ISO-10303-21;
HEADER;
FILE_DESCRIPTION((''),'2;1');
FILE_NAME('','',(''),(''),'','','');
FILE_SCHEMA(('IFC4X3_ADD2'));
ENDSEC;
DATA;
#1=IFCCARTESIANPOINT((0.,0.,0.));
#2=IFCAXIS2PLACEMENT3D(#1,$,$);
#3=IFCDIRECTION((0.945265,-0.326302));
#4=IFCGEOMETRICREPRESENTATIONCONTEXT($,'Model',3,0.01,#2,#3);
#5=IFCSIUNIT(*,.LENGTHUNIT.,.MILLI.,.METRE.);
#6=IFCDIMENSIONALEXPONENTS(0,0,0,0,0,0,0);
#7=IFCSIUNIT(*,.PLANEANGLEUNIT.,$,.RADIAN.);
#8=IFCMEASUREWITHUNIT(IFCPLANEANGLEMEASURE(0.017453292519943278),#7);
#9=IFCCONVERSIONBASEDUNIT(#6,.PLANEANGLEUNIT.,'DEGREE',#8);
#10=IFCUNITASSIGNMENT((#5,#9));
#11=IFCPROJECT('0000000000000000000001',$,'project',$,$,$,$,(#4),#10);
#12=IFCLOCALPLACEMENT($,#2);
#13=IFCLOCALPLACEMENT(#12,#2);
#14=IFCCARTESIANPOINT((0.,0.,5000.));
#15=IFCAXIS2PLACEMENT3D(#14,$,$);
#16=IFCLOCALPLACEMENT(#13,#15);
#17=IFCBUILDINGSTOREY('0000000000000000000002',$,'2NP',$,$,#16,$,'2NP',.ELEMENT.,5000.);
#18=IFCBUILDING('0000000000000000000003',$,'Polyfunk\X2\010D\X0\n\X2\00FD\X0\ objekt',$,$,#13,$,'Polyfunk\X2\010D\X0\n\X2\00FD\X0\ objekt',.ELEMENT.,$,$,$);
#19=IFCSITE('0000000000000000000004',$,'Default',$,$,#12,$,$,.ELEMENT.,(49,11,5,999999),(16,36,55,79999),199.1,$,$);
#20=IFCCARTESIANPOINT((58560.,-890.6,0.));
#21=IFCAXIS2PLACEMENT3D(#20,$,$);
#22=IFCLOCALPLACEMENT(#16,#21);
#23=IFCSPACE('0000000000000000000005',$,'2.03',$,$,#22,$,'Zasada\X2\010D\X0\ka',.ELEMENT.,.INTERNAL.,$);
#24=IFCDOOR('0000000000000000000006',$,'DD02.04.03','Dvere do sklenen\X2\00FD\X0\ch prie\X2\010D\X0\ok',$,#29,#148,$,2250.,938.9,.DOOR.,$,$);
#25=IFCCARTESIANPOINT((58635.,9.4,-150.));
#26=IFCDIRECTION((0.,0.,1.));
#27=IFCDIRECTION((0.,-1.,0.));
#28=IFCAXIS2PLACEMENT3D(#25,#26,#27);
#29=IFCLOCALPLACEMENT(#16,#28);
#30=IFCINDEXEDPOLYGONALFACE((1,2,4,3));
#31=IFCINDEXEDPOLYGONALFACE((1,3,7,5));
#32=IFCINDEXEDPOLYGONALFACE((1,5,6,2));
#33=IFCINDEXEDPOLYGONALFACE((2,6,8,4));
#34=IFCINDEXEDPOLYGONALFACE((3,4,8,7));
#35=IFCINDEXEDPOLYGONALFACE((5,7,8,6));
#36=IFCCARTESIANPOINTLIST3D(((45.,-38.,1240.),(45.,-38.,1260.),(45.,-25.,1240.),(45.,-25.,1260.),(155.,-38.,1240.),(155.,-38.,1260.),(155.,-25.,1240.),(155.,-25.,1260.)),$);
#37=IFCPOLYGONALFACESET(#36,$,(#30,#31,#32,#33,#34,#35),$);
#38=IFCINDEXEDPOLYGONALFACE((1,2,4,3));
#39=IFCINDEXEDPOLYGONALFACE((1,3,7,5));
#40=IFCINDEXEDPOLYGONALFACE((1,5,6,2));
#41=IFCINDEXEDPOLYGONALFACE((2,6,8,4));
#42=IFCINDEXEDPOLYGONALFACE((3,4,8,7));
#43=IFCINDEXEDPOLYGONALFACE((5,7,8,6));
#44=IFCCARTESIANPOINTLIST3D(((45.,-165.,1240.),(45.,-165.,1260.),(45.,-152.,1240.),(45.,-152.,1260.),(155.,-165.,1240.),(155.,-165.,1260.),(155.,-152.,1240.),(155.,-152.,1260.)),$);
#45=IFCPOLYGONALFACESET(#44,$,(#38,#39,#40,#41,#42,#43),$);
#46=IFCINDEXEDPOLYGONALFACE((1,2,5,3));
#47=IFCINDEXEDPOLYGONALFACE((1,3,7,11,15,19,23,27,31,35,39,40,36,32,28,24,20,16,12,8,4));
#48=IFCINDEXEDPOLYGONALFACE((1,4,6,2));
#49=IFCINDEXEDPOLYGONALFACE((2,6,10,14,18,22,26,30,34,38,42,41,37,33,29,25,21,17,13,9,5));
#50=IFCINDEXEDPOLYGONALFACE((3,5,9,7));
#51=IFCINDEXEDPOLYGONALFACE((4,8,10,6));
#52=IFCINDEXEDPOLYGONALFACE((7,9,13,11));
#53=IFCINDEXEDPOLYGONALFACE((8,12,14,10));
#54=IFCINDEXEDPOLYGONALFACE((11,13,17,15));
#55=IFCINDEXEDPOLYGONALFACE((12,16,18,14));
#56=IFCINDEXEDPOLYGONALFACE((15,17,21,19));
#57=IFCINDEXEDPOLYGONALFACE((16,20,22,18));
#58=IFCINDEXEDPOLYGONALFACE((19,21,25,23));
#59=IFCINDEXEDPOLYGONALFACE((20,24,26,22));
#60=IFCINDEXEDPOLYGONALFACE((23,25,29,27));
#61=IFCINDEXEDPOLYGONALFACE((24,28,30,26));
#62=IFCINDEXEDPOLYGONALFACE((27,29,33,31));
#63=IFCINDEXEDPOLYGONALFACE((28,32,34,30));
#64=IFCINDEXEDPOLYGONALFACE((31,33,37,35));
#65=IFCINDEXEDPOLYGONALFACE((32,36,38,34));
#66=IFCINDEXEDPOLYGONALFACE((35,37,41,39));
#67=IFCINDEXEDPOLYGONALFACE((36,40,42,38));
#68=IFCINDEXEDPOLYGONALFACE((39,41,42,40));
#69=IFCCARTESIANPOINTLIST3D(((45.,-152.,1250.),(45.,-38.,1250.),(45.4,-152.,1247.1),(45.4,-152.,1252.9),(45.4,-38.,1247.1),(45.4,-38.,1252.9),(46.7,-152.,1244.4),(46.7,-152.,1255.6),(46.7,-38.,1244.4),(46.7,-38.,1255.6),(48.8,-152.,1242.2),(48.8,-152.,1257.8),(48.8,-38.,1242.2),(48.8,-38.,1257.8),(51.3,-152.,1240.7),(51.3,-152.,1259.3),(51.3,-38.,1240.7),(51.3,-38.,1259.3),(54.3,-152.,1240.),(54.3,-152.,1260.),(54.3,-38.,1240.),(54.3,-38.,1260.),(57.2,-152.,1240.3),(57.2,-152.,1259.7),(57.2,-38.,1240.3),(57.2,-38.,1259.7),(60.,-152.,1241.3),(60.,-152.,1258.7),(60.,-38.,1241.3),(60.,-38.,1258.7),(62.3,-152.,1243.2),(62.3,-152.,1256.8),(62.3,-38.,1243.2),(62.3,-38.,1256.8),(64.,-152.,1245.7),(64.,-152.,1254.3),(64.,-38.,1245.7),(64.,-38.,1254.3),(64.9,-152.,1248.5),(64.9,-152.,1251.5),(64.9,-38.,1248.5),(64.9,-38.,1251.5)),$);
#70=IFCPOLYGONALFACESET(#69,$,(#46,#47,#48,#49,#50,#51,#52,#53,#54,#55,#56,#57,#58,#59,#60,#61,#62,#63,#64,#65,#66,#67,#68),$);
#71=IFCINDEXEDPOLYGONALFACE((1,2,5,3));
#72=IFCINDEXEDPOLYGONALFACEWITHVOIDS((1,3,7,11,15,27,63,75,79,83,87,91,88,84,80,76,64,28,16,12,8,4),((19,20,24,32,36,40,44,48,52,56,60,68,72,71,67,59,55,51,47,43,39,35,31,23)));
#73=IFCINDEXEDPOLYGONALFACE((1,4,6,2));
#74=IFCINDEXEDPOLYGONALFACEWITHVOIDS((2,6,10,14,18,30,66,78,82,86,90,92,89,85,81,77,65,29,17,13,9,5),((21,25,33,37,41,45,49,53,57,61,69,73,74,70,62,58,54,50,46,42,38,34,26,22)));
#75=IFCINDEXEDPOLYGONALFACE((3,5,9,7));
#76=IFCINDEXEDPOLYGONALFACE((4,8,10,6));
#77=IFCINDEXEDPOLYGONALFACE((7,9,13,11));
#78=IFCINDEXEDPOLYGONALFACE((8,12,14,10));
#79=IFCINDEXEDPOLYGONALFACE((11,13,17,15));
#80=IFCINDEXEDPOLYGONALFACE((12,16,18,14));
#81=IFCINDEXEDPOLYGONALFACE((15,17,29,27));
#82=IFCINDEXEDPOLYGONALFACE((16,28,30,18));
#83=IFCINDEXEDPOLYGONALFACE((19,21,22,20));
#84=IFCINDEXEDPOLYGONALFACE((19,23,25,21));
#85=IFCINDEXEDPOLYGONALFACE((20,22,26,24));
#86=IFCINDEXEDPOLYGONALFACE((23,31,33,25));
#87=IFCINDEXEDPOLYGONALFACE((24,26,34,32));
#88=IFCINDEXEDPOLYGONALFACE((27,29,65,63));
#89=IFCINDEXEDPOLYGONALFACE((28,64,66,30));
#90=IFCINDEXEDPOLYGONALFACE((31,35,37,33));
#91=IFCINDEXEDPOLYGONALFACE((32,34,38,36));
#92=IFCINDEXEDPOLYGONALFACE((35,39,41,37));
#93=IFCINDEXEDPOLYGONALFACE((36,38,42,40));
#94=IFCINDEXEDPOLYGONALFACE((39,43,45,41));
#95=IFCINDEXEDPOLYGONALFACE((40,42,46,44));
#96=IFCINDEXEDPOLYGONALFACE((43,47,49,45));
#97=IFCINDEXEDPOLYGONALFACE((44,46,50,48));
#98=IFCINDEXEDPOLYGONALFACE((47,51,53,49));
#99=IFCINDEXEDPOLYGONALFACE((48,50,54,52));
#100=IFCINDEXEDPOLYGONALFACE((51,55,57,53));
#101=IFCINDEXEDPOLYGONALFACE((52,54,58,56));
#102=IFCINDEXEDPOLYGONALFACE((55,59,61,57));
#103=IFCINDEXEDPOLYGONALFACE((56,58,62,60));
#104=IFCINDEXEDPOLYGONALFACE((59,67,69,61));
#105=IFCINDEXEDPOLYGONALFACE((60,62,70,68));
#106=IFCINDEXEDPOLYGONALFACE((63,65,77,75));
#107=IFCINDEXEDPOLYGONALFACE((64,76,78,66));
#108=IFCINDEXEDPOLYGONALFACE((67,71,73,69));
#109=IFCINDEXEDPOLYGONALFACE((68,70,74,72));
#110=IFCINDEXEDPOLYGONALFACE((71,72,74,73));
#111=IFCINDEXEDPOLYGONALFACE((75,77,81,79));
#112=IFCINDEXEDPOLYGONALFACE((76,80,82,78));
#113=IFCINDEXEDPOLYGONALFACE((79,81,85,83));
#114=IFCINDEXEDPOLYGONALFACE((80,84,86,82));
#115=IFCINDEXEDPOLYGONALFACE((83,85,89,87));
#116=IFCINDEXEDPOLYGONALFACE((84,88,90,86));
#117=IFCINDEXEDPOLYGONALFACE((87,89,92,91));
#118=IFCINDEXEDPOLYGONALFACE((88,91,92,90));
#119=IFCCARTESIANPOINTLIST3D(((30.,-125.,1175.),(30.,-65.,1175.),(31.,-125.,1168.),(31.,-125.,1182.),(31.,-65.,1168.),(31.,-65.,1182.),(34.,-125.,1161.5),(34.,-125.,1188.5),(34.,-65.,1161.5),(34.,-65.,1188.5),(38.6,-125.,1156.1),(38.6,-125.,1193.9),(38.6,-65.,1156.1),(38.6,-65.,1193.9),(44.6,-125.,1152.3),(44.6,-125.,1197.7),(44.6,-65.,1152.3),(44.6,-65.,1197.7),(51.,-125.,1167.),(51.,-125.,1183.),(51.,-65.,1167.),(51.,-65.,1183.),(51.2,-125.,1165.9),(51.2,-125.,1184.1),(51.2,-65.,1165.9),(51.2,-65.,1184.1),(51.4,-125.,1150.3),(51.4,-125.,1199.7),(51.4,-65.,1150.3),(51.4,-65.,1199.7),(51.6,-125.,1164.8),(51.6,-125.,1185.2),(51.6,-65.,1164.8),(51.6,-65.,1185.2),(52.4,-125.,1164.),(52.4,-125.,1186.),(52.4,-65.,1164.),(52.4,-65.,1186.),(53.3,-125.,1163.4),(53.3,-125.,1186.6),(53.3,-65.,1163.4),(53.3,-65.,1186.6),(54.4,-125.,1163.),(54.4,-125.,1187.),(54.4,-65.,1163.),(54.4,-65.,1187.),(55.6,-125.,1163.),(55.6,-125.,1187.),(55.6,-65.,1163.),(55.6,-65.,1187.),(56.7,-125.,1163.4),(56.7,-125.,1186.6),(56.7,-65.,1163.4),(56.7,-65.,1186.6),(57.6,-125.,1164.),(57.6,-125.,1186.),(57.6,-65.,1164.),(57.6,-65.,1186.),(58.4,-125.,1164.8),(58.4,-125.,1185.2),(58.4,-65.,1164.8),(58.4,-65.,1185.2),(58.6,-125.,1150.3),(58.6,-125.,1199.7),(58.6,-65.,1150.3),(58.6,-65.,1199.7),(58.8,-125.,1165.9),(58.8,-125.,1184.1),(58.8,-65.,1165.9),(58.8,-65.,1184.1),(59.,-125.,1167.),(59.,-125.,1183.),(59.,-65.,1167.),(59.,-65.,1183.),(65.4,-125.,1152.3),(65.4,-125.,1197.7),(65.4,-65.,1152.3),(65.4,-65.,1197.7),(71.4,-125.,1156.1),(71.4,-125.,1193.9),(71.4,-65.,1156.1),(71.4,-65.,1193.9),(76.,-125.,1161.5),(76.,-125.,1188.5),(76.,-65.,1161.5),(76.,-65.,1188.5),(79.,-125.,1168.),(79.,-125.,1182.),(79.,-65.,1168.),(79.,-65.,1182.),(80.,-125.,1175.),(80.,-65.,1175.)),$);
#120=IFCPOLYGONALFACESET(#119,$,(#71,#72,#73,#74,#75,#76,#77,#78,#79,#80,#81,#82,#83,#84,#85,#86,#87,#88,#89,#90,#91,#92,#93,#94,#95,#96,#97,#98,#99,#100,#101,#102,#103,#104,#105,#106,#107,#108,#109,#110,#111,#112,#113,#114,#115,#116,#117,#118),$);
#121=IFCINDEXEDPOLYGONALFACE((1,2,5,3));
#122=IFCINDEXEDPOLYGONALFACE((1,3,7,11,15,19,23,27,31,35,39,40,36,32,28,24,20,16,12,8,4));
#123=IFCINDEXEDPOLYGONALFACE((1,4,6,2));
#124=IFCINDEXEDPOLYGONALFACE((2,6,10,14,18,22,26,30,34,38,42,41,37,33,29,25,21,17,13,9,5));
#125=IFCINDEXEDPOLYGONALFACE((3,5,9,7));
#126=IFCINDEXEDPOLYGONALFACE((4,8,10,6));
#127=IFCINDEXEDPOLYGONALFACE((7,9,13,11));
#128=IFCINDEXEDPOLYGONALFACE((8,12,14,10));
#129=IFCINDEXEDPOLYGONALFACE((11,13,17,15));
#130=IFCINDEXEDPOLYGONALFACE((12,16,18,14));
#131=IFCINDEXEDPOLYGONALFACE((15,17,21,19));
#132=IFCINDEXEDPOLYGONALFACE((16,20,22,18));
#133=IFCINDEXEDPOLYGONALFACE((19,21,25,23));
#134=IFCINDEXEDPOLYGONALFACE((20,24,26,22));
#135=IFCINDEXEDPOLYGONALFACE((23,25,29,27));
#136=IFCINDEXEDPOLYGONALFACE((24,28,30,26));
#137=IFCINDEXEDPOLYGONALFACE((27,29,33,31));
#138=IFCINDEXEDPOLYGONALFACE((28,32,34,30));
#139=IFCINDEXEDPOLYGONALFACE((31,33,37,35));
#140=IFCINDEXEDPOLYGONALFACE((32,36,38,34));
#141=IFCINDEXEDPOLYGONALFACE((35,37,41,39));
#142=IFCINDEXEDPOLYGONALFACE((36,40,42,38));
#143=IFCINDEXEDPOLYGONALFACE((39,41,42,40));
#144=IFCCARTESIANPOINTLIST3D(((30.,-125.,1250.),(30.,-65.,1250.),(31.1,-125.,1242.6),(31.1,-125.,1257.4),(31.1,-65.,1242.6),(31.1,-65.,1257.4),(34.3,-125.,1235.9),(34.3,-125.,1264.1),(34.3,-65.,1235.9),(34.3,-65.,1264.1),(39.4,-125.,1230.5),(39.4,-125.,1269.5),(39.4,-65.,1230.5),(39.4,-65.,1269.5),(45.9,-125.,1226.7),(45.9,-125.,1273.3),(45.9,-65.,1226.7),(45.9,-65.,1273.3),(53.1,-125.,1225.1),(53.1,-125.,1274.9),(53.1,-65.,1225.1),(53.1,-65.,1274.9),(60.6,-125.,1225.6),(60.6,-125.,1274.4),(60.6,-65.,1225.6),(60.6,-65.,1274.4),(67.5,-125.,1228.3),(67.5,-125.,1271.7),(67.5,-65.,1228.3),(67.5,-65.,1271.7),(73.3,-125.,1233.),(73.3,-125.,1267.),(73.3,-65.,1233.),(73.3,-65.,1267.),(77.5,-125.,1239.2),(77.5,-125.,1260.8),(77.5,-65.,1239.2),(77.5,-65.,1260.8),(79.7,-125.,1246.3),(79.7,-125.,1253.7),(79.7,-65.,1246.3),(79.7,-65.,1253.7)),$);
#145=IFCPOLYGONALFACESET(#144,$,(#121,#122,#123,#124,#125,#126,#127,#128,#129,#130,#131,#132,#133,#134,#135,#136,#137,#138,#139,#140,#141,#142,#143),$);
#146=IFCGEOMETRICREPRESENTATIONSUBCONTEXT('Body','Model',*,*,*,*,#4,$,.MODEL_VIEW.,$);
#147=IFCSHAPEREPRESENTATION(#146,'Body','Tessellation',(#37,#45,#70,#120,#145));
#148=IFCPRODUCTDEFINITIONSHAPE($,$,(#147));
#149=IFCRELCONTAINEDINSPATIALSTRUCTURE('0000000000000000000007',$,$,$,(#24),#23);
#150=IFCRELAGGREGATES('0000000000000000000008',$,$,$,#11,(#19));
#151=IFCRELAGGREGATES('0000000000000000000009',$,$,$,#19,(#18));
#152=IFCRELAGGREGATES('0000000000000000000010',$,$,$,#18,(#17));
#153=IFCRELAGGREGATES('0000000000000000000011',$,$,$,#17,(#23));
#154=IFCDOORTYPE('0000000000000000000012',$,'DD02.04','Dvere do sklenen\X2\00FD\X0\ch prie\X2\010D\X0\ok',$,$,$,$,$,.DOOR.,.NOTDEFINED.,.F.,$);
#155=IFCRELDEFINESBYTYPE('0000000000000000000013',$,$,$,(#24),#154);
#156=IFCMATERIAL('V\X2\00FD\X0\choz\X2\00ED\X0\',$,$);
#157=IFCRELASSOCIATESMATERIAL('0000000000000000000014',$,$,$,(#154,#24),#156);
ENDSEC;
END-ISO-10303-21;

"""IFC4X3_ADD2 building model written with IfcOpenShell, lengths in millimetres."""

from ifc_helpers import new_model, entity, si_unit, converted_unit, direction, frame, frame_2d, origin, origin_2d_with_axis, place, context, subcontext, project, spatial, polyline, circle_curve, parameter, trimmed, segment, composite_curve, rectangle, circle, outline, extrude, source, transform, mapped, material, type_object, type_shapes, element, save


model = new_model("IFC4X3_ADD2")

# Units and contexts
model_context = context("Model", 3, precision=0.01, world=origin(), true_north=direction((0.945265, -0.326302)))
body_context = subcontext(model_context, "Body", "Model", "MODEL_VIEW")
ifc_project = project(units=[si_unit("LENGTHUNIT", "METRE", prefix="MILLI"), converted_unit("PLANEANGLEUNIT", "DEGREE", entity("IfcPlaneAngleMeasure", 0.017453292519943278), si_unit("PLANEANGLEUNIT", "RADIAN"), dimensions=[0, 0, 0, 0, 0, 0, 0])], contexts=[model_context])

# Site, building, storey
site_placement = place(None, origin())
site = spatial("IfcSite", under=ifc_project, at=site_placement, Name="Default", CompositionType="ELEMENT", RefLatitude=(49, 11, 5, 999999), RefLongitude=(16, 36, 55, 79999), RefElevation=199.1)
building_placement = place(site_placement, origin())
building = spatial("IfcBuilding", under=site, at=building_placement, Name="Polyfunkčný objekt", LongName="Polyfunkčný objekt", CompositionType="ELEMENT")
storey_placement = place(building_placement, frame((0.0, 0.0, 5000.0)))
storey = spatial("IfcBuildingStorey", under=building, at=storey_placement, Name="2NP", LongName="2NP", CompositionType="ELEMENT", Elevation=5000.0)

# Shared definitions
space_placement = place(storey_placement, frame((58560.0, -890.6, 0.0)))
space = spatial("IfcSpace", under=storey, at=space_placement, Name="2.03", LongName="Zasadačka", CompositionType="ELEMENT", PredefinedType="INTERNAL")

# Door
ifc_material_1 = material(Name="Výchozí")
door_type = type_object("IfcDoorType", Name="DD02.04", Description="Dvere do sklenených priečok", OperationType="NOTDEFINED", ParameterTakesPrecedence=False, PredefinedType="DOOR", material=ifc_material_1)
shared_shape_1 = source(origin(), body_context, "Body", "SweptSolid", [
    extrude(rectangle(XDim=110.0, YDim=13.0, at=frame_2d((0.0, 0.0), x_axis=(1.0, 0.0))), frame((100.0, -31.5, 1240.0)), (0.0, 0.0, 1.0), 20.0),
    extrude(rectangle(XDim=110.0, YDim=13.0, at=origin_2d_with_axis()), frame((100.0, -158.5, 1240.0), z_axis=(0.0, 0.0, 1.0), x_axis=(-1.0, 0.0, 0.0)), (0.0, 0.0, 1.0), 20.0),
    extrude(circle(Radius=10.0, at=origin_2d_with_axis()), frame((55.0, -152.0, 1250.0), z_axis=(0.0, 1.0, 0.0), x_axis=(-1.0, 0.0, 0.0)), (0.0, 0.0, 1.0), 114.0),
    extrude(outline(composite_curve([segment(trimmed(circle_curve(origin_2d_with_axis(), 25.0), [parameter(180.0)], [parameter(360.0)], True, "PARAMETER"), True, "CONTINUOUS"), segment(trimmed(circle_curve(origin_2d_with_axis(), 25.0), [parameter(0.0)], [parameter(180.0)], True, "PARAMETER"), True, "CONTINUOUS")], self_intersect=False), holes=[composite_curve([segment(trimmed(circle_curve(frame_2d((0.0, 8.0), x_axis=(1.0, 0.0)), 4.0), [parameter(0.0)], [parameter(180.0)], True, "PARAMETER"), False, "CONTINUOUS"), segment(polyline([(4.0, 8.0), (4.0, -8.0)]), True, "CONTINUOUS"), segment(trimmed(circle_curve(frame_2d((0.0, -8.0), x_axis=(1.0, 0.0)), 4.0), [parameter(180.0)], [parameter(0.0)], True, "PARAMETER"), False, "CONTINUOUS"), segment(polyline([(-4.0, -8.0), (-4.0, 8.0)]), True, "CONTINUOUS")], self_intersect=False)]), frame((55.0, -125.0, 1175.0), z_axis=(0.0, 1.0, 0.0), x_axis=(-1.0, 0.0, 0.0)), (0.0, 0.0, 1.0), 60.0),
    extrude(circle(Radius=25.0, at=frame_2d((0.0, 0.0), x_axis=(1.0, 0.0))), frame((55.0, -125.0, 1250.0), z_axis=(0.0, 1.0, 0.0), x_axis=(-1.0, 0.0, 0.0)), (0.0, 0.0, 1.0), 60.0),
])
type_shapes(door_type, [shared_shape_1])
door_placement = place(storey_placement, frame((58635.0, 9.4, -150.0), z_axis=(0.0, 0.0, 1.0), x_axis=(0.0, -1.0, 0.0)))
element("IfcDoor", 1, at=door_placement, inside=space, type_object=door_type, material=ifc_material_1, Name="DD02.04.03", Description="Dvere do sklenených priečok", OverallHeight=2250.0, OverallWidth=938.9, PredefinedType="DOOR", context=body_context, shape_type="MappedRepresentation", body=[
    mapped(shared_shape_1, transform((0.0, 0.0, 0.0), scale=1.0)),
])

save(model, "model.ifc")
